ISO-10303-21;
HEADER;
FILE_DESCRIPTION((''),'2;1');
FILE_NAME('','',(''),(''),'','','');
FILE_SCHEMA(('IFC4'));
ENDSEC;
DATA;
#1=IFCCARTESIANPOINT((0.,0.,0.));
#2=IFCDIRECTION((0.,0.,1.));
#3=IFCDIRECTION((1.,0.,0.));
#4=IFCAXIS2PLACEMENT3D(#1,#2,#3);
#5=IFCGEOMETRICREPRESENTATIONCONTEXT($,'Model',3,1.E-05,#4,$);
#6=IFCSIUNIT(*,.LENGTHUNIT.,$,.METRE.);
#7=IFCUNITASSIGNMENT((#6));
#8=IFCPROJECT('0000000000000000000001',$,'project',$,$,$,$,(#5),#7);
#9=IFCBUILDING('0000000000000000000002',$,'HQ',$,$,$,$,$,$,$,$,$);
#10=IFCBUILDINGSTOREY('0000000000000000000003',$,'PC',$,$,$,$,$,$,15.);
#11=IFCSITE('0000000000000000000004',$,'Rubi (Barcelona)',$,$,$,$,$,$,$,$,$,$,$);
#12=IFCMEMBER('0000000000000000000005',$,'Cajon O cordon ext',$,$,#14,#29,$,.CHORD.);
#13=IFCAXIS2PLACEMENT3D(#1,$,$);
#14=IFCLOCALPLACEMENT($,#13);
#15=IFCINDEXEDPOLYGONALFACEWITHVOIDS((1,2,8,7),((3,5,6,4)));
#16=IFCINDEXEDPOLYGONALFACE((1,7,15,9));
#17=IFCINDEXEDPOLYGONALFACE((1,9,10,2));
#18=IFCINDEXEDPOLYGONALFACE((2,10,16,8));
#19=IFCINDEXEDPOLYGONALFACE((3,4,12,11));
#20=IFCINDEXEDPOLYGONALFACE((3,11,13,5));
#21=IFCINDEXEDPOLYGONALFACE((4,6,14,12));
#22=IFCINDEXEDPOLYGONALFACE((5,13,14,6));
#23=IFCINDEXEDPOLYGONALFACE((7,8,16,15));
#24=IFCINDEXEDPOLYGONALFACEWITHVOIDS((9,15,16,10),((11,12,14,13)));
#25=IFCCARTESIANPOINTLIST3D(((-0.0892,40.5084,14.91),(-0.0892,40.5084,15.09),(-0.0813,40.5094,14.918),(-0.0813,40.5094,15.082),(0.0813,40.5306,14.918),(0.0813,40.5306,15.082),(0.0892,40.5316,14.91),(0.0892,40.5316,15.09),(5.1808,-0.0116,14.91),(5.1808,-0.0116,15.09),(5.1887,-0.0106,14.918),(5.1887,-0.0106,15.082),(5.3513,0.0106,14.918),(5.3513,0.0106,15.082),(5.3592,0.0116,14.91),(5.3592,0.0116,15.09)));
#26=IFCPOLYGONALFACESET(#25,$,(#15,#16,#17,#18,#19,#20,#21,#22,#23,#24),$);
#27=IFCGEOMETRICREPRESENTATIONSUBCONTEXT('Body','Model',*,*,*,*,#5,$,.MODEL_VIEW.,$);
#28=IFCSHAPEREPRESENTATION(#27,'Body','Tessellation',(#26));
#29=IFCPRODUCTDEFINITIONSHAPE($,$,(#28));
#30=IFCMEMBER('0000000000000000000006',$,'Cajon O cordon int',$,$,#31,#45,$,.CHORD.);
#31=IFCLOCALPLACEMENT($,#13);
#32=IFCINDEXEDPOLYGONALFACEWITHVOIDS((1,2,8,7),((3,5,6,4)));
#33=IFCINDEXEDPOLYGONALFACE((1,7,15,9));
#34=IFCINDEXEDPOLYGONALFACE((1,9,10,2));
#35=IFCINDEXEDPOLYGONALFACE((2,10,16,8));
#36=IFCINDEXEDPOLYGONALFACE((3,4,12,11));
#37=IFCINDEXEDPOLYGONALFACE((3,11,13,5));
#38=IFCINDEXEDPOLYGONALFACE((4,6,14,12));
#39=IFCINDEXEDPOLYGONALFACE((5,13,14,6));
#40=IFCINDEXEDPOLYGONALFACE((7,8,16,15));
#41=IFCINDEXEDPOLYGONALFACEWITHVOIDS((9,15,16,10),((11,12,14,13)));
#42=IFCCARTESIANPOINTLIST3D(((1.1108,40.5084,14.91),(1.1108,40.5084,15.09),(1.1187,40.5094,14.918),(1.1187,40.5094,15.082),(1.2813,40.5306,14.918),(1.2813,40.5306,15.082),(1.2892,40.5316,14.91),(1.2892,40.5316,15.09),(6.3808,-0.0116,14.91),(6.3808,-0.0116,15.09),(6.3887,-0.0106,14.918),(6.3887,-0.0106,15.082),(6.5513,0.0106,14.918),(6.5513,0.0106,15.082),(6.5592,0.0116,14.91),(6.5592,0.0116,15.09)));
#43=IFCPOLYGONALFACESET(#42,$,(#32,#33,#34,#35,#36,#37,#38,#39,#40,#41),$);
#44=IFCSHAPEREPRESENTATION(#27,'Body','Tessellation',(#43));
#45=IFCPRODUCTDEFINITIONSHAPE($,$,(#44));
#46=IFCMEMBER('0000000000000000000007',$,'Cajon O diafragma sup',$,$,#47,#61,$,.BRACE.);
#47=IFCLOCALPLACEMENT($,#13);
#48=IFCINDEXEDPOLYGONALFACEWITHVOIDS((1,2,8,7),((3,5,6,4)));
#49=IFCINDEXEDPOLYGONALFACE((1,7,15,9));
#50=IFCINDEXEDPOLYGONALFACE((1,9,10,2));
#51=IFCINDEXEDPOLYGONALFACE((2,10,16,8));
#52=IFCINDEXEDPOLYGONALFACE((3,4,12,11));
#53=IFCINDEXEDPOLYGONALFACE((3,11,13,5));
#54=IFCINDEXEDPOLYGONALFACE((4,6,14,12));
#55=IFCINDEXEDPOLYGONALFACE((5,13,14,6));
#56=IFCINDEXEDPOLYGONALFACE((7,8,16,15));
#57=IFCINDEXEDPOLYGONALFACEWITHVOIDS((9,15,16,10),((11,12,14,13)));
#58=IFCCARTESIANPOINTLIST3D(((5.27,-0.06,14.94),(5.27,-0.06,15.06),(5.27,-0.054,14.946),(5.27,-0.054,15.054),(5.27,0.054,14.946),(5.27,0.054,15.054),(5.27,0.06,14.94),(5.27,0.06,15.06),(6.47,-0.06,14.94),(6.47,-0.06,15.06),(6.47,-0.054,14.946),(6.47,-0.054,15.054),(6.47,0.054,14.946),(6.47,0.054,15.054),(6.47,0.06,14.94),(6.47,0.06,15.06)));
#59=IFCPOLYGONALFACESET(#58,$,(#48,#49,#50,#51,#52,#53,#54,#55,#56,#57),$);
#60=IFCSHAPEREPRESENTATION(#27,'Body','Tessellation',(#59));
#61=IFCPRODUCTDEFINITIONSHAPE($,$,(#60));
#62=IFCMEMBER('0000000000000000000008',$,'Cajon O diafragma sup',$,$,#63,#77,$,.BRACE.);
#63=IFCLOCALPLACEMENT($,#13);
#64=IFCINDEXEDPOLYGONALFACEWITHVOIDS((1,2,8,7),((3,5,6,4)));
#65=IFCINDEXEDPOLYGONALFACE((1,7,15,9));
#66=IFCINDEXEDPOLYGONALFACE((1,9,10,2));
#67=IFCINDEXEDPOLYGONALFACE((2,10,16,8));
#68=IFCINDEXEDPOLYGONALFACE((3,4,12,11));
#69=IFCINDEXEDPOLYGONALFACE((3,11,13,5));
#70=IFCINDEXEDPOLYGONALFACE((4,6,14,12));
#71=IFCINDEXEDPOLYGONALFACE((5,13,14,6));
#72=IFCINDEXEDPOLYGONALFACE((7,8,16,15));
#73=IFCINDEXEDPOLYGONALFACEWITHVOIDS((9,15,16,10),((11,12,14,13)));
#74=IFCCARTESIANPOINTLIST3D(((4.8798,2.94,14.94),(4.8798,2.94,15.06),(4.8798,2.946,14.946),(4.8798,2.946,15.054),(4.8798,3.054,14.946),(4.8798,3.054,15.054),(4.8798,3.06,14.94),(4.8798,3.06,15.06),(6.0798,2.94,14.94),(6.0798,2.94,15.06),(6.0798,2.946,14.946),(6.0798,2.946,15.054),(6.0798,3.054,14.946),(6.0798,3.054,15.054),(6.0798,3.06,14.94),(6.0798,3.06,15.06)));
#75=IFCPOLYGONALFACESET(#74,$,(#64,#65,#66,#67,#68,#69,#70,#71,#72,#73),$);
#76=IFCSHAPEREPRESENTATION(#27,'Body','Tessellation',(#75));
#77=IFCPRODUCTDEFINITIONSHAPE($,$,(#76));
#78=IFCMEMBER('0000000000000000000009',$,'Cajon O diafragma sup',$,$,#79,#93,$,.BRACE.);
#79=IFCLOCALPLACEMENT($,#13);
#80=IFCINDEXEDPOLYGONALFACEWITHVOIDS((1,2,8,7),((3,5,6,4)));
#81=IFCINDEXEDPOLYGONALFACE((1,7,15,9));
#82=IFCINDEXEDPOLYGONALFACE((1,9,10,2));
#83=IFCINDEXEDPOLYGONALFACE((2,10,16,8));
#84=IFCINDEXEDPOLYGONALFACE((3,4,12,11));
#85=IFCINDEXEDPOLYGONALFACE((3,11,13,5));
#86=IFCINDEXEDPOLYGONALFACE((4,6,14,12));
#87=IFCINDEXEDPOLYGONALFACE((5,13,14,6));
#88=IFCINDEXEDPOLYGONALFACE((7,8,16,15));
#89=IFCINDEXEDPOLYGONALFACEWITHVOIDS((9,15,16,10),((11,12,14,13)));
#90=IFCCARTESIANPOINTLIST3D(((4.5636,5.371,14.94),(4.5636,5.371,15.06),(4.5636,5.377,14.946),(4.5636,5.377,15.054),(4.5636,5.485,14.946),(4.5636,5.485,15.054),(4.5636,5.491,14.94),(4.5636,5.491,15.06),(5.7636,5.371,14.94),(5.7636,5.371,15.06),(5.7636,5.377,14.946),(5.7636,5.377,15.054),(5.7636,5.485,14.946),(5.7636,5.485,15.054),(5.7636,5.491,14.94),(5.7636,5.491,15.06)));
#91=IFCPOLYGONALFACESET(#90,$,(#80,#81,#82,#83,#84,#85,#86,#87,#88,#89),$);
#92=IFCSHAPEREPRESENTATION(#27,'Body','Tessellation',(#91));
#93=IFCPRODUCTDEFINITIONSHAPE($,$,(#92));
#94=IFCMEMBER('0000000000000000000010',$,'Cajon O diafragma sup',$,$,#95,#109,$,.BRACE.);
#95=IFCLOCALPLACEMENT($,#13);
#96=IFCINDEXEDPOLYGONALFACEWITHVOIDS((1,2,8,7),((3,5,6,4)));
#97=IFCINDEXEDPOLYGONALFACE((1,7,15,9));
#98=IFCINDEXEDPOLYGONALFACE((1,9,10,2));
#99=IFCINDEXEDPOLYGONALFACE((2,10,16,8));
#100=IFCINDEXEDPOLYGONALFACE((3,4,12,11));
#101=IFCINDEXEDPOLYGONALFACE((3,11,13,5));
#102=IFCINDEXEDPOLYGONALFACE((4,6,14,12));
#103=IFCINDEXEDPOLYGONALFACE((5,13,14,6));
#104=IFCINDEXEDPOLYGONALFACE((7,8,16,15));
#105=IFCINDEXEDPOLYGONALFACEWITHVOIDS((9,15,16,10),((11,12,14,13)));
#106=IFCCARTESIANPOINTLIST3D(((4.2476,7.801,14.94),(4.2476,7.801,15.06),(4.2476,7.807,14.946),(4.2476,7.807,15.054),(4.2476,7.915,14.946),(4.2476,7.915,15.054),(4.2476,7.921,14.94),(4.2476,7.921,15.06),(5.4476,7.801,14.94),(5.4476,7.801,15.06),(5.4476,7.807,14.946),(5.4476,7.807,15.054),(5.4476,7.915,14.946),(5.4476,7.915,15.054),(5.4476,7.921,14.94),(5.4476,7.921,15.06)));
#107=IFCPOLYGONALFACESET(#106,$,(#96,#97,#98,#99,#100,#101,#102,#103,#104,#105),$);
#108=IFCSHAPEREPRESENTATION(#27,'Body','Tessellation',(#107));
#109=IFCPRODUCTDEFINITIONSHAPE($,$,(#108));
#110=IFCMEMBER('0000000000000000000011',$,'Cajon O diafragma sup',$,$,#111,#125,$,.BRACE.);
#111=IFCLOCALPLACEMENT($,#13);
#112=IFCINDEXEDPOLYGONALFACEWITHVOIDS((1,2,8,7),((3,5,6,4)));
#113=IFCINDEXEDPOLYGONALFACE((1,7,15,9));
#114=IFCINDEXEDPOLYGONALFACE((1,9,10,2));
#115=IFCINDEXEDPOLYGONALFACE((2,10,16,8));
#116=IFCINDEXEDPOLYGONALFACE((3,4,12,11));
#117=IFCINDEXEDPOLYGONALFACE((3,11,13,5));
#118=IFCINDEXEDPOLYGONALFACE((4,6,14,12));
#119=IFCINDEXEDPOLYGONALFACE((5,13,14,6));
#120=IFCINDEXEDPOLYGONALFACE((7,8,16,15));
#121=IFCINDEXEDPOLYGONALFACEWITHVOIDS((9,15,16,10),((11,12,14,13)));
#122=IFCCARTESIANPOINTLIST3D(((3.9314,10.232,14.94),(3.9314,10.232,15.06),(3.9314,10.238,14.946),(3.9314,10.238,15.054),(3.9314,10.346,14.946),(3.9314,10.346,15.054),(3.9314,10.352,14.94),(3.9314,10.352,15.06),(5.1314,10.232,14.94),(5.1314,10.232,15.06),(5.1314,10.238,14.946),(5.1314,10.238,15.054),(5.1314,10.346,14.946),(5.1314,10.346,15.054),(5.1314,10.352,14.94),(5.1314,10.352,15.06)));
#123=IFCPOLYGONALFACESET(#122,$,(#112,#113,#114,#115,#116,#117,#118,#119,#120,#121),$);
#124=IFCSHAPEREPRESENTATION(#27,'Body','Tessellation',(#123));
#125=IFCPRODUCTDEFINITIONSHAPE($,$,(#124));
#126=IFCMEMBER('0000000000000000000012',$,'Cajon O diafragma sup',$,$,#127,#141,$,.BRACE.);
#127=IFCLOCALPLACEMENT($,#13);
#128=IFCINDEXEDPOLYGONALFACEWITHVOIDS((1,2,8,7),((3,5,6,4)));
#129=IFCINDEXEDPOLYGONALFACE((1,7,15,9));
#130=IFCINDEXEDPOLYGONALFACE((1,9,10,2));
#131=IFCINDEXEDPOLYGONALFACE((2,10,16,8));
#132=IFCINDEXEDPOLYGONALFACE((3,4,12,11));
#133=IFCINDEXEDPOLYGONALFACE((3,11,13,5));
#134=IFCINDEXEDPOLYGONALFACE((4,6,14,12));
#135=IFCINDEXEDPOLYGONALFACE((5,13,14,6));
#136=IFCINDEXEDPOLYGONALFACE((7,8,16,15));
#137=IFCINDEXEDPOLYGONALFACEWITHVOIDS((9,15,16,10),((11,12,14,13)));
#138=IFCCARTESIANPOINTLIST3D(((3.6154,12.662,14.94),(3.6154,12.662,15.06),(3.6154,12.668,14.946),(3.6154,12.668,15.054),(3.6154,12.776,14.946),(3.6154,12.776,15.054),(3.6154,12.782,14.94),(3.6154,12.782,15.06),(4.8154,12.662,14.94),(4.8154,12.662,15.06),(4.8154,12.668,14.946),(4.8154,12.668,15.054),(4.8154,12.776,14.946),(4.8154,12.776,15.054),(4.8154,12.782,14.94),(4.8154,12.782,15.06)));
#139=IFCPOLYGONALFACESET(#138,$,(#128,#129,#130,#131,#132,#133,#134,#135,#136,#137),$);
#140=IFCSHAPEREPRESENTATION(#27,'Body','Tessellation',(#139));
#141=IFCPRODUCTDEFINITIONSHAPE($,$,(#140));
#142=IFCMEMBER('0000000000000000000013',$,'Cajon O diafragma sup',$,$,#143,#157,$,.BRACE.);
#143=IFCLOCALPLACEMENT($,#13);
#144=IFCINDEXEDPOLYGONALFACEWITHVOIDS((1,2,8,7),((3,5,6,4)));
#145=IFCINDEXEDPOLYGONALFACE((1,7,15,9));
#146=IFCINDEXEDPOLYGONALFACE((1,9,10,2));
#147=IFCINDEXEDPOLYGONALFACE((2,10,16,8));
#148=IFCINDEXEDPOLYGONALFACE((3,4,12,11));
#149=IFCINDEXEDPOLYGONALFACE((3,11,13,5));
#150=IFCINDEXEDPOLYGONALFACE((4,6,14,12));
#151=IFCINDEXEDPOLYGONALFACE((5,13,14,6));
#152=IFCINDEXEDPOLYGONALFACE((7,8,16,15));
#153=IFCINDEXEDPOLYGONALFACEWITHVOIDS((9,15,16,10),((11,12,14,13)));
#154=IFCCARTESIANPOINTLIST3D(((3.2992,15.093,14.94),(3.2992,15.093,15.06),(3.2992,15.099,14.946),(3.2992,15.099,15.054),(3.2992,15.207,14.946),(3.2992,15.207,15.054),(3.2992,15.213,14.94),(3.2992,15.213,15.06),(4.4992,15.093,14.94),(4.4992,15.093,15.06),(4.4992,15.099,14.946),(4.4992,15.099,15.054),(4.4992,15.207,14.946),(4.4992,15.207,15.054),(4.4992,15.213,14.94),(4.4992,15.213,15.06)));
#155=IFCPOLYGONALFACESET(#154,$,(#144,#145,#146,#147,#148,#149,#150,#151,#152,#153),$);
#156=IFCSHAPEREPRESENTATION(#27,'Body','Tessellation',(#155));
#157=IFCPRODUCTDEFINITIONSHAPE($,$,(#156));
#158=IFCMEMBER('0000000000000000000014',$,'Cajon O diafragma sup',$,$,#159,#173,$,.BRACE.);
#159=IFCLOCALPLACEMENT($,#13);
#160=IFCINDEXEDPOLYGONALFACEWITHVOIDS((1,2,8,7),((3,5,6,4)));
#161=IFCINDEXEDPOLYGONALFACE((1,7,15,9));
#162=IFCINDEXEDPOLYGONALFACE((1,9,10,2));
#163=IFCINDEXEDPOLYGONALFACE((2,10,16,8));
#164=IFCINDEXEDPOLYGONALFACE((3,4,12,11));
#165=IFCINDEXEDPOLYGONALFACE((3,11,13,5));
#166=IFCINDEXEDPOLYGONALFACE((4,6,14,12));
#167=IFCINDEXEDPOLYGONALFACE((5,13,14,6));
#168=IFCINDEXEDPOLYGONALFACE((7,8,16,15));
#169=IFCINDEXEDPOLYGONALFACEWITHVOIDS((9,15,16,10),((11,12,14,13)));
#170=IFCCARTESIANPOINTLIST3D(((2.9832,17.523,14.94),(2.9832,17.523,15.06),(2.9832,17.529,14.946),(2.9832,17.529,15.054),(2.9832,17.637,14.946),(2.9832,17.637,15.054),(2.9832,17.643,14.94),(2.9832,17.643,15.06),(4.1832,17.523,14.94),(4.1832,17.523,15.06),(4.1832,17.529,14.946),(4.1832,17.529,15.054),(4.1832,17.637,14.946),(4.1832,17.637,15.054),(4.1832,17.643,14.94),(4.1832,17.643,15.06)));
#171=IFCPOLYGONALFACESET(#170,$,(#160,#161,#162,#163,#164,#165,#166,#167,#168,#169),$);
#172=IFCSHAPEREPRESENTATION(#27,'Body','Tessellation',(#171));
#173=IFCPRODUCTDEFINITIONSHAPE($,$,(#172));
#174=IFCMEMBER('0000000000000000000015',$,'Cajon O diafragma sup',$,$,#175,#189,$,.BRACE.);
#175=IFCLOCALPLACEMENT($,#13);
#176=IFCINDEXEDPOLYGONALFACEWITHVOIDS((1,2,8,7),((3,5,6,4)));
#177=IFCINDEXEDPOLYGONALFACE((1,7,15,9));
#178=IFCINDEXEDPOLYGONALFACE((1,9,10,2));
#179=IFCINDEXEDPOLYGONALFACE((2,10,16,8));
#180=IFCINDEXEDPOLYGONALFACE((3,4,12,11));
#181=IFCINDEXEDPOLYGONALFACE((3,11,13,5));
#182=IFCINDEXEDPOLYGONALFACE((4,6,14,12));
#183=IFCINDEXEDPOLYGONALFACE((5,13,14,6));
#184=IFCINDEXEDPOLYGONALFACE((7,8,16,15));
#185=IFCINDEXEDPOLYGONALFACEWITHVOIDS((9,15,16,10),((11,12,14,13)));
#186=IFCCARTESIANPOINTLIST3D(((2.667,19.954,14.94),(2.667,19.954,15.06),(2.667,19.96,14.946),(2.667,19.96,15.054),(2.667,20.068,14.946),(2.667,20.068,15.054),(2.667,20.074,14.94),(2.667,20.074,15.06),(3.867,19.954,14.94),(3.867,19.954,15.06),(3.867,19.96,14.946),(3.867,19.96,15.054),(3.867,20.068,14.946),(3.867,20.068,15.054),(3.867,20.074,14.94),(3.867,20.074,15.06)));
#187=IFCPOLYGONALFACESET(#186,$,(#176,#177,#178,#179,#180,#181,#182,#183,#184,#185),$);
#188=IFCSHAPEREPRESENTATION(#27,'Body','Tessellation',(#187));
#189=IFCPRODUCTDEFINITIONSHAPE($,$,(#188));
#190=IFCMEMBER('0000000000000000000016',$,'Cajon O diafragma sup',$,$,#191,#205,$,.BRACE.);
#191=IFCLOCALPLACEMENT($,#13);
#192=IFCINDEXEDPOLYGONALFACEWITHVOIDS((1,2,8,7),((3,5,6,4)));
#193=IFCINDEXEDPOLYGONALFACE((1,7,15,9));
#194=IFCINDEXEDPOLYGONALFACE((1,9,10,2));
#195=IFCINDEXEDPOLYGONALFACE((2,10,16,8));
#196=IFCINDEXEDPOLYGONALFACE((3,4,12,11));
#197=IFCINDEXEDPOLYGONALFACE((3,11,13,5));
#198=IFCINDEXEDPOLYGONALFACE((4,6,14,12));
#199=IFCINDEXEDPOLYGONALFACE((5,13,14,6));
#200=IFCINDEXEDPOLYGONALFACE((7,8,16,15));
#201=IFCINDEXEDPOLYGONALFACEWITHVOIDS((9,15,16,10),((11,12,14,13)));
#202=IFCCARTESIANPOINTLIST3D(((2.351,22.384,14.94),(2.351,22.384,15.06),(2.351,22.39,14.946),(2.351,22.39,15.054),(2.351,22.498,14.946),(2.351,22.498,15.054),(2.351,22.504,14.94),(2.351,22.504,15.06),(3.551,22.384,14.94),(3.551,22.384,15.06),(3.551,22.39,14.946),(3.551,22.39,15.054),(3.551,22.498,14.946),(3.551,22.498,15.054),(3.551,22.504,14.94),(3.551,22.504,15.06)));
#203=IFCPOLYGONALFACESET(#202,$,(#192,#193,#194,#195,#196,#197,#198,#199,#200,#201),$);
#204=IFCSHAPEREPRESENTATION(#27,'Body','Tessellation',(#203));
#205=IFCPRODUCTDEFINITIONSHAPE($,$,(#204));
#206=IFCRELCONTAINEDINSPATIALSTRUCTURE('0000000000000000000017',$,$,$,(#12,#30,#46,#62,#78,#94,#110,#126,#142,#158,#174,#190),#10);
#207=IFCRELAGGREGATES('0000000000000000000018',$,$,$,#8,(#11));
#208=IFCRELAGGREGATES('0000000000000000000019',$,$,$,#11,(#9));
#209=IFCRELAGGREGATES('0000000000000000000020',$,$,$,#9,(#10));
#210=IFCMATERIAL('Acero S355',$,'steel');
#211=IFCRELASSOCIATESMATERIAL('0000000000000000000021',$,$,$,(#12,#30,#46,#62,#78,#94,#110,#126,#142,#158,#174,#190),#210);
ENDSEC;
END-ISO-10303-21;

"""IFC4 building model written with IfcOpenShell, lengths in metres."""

from ifc_helpers import new_model, si_unit, frame, origin_with_axes, place, context, subcontext, project, spatial, hollow_rectangle, extrude, material, element, save


model = new_model("IFC4")

# Units and contexts
model_context = context("Model", 3, precision=1e-05, world=origin_with_axes())
body_context = subcontext(model_context, "Body", "Model", "MODEL_VIEW")
ifc_project = project(units=[si_unit("LENGTHUNIT", "METRE")], contexts=[model_context])

# Site, building, storey
site = spatial("IfcSite", under=ifc_project, Name="Rubi (Barcelona)")
building = spatial("IfcBuilding", under=site, Name="HQ")
storey = spatial("IfcBuildingStorey", under=building, Name="PC", Elevation=15.0)

# Members
ifc_material = material(Name="Acero S355", Category="steel")
member_1_placement = place(None, origin_with_axes())
element("IfcMember", 1, at=member_1_placement, inside=storey, material=ifc_material, Name="Cajon O cordon ext", PredefinedType="CHORD", context=body_context, shape_type="SweptSolid", body=[
    extrude(hollow_rectangle(XDim=0.18, YDim=0.18, WallThickness=0.008), frame((5.27, 0.0, 15.0), z_axis=(-0.128973, 0.991648, 0.0), x_axis=(-0.991648, -0.128973, 0.0)), (0.0, 0.0, 1.0), 40.8613),
])
member_2_placement = place(None, origin_with_axes())
element("IfcMember", 2, at=member_2_placement, inside=storey, material=ifc_material, Name="Cajon O cordon int", PredefinedType="CHORD", context=body_context, shape_type="SweptSolid", body=[
    extrude(hollow_rectangle(XDim=0.18, YDim=0.18, WallThickness=0.008), frame((6.47, 0.0, 15.0), z_axis=(-0.128973, 0.991648, 0.0), x_axis=(-0.991648, -0.128973, 0.0)), (0.0, 0.0, 1.0), 40.8613),
])
member_3_placement = place(None, origin_with_axes())
element("IfcMember", 3, at=member_3_placement, inside=storey, material=ifc_material, Name="Cajon O diafragma sup", PredefinedType="BRACE", context=body_context, shape_type="SweptSolid", body=[
    extrude(hollow_rectangle(XDim=0.12, YDim=0.12, WallThickness=0.006), frame((5.27, 0.0, 15.0), z_axis=(1.0, 0.0, 0.0), x_axis=(0.0, 1.0, 0.0)), (0.0, 0.0, 1.0), 1.2),
])
member_4_placement = place(None, origin_with_axes())
element("IfcMember", 4, at=member_4_placement, inside=storey, material=ifc_material, Name="Cajon O diafragma sup", PredefinedType="BRACE", context=body_context, shape_type="SweptSolid", body=[
    extrude(hollow_rectangle(XDim=0.12, YDim=0.12, WallThickness=0.006), frame((4.8798, 3.0, 15.0), z_axis=(1.0, 0.0, 0.0), x_axis=(0.0, 1.0, 0.0)), (0.0, 0.0, 1.0), 1.2),
])
member_5_placement = place(None, origin_with_axes())
element("IfcMember", 5, at=member_5_placement, inside=storey, material=ifc_material, Name="Cajon O diafragma sup", PredefinedType="BRACE", context=body_context, shape_type="SweptSolid", body=[
    extrude(hollow_rectangle(XDim=0.12, YDim=0.12, WallThickness=0.006), frame((4.5636, 5.431, 15.0), z_axis=(1.0, 0.0, 0.0), x_axis=(0.0, 1.0, 0.0)), (0.0, 0.0, 1.0), 1.2),
])
member_6_placement = place(None, origin_with_axes())
element("IfcMember", 6, at=member_6_placement, inside=storey, material=ifc_material, Name="Cajon O diafragma sup", PredefinedType="BRACE", context=body_context, shape_type="SweptSolid", body=[
    extrude(hollow_rectangle(XDim=0.12, YDim=0.12, WallThickness=0.006), frame((4.2476, 7.861, 15.0), z_axis=(1.0, 0.0, 0.0), x_axis=(0.0, 1.0, 0.0)), (0.0, 0.0, 1.0), 1.2),
])
member_7_placement = place(None, origin_with_axes())
element("IfcMember", 7, at=member_7_placement, inside=storey, material=ifc_material, Name="Cajon O diafragma sup", PredefinedType="BRACE", context=body_context, shape_type="SweptSolid", body=[
    extrude(hollow_rectangle(XDim=0.12, YDim=0.12, WallThickness=0.006), frame((3.9314, 10.292, 15.0), z_axis=(1.0, 0.0, 0.0), x_axis=(0.0, 1.0, 0.0)), (0.0, 0.0, 1.0), 1.2),
])
member_8_placement = place(None, origin_with_axes())
element("IfcMember", 8, at=member_8_placement, inside=storey, material=ifc_material, Name="Cajon O diafragma sup", PredefinedType="BRACE", context=body_context, shape_type="SweptSolid", body=[
    extrude(hollow_rectangle(XDim=0.12, YDim=0.12, WallThickness=0.006), frame((3.6154, 12.722, 15.0), z_axis=(1.0, 0.0, 0.0), x_axis=(0.0, 1.0, 0.0)), (0.0, 0.0, 1.0), 1.2),
])
member_9_placement = place(None, origin_with_axes())
element("IfcMember", 9, at=member_9_placement, inside=storey, material=ifc_material, Name="Cajon O diafragma sup", PredefinedType="BRACE", context=body_context, shape_type="SweptSolid", body=[
    extrude(hollow_rectangle(XDim=0.12, YDim=0.12, WallThickness=0.006), frame((3.2992, 15.153, 15.0), z_axis=(1.0, 0.0, 0.0), x_axis=(0.0, 1.0, 0.0)), (0.0, 0.0, 1.0), 1.2),
])
member_10_placement = place(None, origin_with_axes())
element("IfcMember", 10, at=member_10_placement, inside=storey, material=ifc_material, Name="Cajon O diafragma sup", PredefinedType="BRACE", context=body_context, shape_type="SweptSolid", body=[
    extrude(hollow_rectangle(XDim=0.12, YDim=0.12, WallThickness=0.006), frame((2.9832, 17.583, 15.0), z_axis=(1.0, 0.0, 0.0), x_axis=(0.0, 1.0, 0.0)), (0.0, 0.0, 1.0), 1.2),
])
member_11_placement = place(None, origin_with_axes())
element("IfcMember", 11, at=member_11_placement, inside=storey, material=ifc_material, Name="Cajon O diafragma sup", PredefinedType="BRACE", context=body_context, shape_type="SweptSolid", body=[
    extrude(hollow_rectangle(XDim=0.12, YDim=0.12, WallThickness=0.006), frame((2.667, 20.014, 15.0), z_axis=(1.0, 0.0, 0.0), x_axis=(0.0, 1.0, 0.0)), (0.0, 0.0, 1.0), 1.2),
])
member_12_placement = place(None, origin_with_axes())
element("IfcMember", 12, at=member_12_placement, inside=storey, material=ifc_material, Name="Cajon O diafragma sup", PredefinedType="BRACE", context=body_context, shape_type="SweptSolid", body=[
    extrude(hollow_rectangle(XDim=0.12, YDim=0.12, WallThickness=0.006), frame((2.351, 22.444, 15.0), z_axis=(1.0, 0.0, 0.0), x_axis=(0.0, 1.0, 0.0)), (0.0, 0.0, 1.0), 1.2),
])

save(model, "model.ifc")
